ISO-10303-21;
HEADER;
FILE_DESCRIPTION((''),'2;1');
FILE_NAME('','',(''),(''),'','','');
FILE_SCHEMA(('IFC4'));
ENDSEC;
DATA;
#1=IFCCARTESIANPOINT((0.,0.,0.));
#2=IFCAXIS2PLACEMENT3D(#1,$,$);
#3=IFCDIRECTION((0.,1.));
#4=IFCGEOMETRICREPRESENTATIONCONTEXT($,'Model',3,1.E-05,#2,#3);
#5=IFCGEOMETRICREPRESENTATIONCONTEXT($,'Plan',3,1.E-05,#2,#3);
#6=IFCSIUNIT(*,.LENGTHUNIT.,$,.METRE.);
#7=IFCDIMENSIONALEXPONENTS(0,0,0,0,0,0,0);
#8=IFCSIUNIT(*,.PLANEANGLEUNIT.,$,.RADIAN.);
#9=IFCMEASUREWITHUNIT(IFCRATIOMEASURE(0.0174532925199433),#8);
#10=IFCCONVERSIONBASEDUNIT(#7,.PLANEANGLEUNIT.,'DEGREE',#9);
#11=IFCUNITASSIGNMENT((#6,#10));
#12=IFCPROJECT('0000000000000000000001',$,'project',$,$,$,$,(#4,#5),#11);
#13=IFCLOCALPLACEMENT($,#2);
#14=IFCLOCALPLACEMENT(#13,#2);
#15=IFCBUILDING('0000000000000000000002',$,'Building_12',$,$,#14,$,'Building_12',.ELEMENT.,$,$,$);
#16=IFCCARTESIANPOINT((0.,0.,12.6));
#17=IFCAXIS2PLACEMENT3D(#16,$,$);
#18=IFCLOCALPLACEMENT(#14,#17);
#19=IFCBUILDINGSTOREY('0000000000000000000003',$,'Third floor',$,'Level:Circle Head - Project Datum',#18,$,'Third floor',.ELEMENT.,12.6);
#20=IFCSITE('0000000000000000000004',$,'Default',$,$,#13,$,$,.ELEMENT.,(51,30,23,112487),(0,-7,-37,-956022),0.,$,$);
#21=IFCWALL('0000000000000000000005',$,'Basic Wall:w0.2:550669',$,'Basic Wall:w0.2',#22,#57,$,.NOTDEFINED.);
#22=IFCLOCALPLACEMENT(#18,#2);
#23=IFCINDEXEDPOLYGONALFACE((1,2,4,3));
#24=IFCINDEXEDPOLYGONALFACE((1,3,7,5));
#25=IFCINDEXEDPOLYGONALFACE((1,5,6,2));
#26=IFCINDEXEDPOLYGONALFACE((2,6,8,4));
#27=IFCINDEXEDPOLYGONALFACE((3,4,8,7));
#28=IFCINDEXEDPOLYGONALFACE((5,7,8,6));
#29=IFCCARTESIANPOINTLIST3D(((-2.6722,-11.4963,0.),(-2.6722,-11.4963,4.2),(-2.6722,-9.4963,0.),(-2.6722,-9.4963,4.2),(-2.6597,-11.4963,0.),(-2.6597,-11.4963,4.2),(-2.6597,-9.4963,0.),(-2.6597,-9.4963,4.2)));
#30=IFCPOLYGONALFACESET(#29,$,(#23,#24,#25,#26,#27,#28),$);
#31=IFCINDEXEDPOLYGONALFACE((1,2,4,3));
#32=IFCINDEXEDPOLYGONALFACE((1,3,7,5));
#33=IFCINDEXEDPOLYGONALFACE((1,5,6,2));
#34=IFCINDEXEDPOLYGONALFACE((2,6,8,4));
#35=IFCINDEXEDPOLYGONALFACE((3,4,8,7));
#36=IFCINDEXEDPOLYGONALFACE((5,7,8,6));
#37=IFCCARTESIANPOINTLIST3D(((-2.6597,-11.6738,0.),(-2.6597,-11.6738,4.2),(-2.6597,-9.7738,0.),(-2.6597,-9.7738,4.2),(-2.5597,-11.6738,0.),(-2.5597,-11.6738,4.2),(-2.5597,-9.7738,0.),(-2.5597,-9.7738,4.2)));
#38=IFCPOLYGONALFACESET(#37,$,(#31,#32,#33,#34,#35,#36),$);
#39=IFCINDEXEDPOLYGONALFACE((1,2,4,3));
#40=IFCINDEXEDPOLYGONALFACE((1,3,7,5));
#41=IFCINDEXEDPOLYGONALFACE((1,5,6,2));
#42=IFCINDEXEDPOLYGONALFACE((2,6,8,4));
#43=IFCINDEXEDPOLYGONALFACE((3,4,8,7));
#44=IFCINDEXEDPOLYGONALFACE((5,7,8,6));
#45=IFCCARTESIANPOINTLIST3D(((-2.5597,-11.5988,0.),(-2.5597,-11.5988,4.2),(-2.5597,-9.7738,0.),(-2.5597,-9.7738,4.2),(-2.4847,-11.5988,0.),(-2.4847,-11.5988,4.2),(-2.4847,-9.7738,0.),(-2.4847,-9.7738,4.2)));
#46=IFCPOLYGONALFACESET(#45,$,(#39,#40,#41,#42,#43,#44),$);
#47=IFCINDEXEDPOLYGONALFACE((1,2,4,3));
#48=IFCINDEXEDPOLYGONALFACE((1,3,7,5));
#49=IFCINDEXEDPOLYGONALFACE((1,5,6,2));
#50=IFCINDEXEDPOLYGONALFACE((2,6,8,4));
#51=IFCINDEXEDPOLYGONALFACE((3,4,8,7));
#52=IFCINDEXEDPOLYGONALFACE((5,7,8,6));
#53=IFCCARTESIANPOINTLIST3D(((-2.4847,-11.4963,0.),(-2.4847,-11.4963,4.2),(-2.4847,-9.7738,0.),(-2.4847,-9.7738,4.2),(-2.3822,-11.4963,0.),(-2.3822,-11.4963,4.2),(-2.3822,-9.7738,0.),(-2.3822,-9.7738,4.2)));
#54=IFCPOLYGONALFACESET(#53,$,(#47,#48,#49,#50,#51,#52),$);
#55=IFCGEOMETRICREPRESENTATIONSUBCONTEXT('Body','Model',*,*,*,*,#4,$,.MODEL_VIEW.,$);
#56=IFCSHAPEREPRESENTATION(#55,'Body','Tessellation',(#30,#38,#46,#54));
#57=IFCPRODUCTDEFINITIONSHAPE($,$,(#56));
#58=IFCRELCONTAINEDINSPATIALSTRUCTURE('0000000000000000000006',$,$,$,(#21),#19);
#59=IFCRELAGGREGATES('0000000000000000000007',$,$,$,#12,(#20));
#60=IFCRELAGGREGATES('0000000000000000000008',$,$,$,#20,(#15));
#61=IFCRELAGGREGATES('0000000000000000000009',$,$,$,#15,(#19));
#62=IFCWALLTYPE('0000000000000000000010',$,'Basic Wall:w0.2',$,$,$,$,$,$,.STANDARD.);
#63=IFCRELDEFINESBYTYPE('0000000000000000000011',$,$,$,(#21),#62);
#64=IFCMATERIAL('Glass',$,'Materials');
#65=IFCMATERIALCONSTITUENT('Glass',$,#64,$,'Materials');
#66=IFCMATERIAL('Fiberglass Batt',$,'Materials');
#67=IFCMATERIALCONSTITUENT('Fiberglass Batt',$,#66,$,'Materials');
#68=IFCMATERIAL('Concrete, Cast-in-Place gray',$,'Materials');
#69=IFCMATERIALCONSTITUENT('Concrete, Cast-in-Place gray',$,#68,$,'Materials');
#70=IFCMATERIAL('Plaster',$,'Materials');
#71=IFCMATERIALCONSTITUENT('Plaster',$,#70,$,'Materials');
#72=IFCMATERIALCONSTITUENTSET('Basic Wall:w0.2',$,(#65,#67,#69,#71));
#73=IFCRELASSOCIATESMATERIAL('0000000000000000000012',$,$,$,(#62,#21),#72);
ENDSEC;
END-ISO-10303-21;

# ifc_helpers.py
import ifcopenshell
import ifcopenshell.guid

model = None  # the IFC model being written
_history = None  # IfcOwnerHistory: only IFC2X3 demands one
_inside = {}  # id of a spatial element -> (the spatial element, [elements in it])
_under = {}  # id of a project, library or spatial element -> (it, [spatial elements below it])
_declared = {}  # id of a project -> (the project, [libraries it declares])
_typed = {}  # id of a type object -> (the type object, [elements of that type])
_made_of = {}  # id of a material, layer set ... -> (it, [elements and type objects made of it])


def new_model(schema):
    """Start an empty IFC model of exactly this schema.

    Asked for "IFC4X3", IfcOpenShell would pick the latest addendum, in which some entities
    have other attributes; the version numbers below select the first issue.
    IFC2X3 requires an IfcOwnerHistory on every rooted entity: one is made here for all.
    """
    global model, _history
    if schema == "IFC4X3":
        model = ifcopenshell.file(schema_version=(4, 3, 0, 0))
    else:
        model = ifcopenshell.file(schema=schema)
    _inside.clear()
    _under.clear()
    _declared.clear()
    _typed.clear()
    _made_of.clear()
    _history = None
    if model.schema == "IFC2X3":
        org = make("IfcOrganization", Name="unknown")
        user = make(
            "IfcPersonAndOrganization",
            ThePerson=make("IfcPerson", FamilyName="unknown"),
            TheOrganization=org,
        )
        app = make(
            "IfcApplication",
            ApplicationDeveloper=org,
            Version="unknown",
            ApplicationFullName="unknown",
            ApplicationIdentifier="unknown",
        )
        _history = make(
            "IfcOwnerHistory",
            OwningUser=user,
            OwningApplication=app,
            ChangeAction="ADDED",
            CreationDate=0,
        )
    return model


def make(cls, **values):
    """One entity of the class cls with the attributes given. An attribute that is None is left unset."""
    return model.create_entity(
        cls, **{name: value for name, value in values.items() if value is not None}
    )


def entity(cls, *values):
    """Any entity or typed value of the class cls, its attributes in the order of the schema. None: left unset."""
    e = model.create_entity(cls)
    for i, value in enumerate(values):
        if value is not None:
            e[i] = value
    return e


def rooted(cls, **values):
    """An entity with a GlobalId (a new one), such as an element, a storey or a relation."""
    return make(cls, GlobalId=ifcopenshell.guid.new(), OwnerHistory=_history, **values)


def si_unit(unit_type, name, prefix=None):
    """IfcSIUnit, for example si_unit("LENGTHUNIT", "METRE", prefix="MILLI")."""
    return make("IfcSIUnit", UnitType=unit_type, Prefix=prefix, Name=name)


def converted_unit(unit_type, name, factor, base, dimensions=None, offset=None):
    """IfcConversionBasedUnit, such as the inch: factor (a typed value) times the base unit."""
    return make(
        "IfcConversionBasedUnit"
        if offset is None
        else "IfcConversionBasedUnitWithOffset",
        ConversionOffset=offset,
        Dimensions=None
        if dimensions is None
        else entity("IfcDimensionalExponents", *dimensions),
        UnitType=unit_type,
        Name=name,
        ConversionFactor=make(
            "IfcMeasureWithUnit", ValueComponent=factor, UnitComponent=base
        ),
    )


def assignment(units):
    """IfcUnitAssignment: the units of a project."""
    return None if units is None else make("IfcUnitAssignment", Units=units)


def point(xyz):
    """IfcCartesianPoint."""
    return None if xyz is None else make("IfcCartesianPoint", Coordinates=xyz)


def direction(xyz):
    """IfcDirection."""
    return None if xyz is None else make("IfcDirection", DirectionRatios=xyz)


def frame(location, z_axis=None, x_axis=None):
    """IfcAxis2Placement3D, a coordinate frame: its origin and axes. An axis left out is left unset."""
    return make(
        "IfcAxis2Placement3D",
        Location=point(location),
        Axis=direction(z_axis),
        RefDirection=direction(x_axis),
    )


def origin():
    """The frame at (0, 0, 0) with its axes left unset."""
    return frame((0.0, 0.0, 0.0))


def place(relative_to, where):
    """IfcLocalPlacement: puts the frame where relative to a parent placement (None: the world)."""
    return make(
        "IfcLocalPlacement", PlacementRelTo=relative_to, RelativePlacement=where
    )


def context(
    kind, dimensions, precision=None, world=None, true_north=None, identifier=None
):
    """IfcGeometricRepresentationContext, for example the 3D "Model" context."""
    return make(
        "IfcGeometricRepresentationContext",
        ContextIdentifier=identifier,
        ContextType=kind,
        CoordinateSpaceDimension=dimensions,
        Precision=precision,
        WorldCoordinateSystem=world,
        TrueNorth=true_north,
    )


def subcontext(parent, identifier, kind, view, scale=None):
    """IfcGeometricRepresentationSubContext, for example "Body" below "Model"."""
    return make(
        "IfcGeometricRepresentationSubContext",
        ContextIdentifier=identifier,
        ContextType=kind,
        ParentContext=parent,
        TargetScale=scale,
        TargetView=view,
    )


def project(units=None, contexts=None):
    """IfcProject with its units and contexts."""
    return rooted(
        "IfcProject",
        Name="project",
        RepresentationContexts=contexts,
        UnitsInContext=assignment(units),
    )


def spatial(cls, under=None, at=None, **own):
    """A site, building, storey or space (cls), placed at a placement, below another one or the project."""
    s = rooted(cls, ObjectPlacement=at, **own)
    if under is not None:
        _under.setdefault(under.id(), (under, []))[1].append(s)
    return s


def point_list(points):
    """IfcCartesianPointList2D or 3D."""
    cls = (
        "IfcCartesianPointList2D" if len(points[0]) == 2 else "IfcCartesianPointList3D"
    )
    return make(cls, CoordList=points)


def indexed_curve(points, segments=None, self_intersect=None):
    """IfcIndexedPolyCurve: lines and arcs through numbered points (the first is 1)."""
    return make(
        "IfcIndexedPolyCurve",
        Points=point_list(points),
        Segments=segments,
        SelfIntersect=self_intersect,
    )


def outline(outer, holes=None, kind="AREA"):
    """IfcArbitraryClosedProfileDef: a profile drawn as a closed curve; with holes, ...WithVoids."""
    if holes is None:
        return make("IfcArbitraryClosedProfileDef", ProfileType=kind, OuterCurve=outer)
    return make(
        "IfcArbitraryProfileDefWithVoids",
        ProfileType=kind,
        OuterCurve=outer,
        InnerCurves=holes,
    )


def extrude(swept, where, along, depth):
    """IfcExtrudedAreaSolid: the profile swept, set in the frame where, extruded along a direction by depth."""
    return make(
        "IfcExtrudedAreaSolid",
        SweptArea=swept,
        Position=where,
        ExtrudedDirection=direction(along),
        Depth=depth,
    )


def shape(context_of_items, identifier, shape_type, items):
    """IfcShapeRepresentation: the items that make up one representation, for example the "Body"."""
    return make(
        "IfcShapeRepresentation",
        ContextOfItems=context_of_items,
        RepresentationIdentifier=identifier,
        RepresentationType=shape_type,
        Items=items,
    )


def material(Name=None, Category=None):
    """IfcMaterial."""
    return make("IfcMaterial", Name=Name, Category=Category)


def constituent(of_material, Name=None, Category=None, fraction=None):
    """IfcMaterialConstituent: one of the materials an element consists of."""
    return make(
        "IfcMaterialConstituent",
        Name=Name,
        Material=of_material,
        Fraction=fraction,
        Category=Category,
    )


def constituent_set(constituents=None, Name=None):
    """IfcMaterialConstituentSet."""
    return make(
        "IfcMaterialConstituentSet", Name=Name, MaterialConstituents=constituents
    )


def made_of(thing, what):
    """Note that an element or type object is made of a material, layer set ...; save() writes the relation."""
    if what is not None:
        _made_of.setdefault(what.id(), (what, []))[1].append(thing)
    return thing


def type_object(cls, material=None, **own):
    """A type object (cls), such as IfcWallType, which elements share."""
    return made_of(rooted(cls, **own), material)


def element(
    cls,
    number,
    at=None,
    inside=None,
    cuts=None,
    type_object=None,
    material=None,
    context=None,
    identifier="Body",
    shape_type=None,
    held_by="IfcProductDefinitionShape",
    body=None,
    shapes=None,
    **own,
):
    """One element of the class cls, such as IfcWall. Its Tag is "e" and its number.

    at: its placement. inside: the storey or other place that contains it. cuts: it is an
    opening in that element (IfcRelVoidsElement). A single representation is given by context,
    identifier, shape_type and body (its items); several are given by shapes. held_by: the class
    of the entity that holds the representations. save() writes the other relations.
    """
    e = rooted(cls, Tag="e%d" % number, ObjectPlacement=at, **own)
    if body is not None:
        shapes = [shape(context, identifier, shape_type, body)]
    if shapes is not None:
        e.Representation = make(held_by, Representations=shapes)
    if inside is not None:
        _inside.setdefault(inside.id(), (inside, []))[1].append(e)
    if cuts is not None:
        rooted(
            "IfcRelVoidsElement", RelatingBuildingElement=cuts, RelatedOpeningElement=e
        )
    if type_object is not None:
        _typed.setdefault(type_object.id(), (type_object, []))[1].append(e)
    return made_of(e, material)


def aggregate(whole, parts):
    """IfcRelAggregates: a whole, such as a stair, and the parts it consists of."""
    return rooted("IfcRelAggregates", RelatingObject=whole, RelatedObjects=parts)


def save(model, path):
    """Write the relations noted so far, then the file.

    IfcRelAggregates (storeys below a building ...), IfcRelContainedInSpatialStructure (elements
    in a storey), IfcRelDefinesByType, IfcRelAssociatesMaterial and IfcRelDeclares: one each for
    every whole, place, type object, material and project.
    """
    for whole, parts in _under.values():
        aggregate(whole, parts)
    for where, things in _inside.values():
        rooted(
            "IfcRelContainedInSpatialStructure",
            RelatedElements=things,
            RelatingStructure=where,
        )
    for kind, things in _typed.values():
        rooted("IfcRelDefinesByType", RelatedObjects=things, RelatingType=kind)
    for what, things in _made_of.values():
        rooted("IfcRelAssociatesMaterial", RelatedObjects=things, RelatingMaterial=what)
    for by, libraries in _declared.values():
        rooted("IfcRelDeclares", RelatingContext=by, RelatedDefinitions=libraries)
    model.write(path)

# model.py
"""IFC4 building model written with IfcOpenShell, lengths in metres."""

from ifc_helpers import new_model, entity, si_unit, converted_unit, direction, frame, origin, place, context, subcontext, project, spatial, indexed_curve, outline, extrude, material, constituent, constituent_set, type_object, element, save


model = new_model("IFC4")

# Units and contexts
model_context = context("Model", 3, precision=1e-05, world=origin(), true_north=direction((0.0, 1.0)))
plan_context = context("Plan", 3, precision=1e-05, world=origin(), true_north=direction((0.0, 1.0)))
body_context = subcontext(model_context, "Body", "Model", "MODEL_VIEW")
ifc_project = project(units=[si_unit("LENGTHUNIT", "METRE"), converted_unit("PLANEANGLEUNIT", "DEGREE", entity("IfcRatioMeasure", 0.0174532925199433), si_unit("PLANEANGLEUNIT", "RADIAN"), dimensions=[0, 0, 0, 0, 0, 0, 0])], contexts=[model_context, plan_context])

# Site, building, storey
site_placement = place(None, origin())
site = spatial("IfcSite", under=ifc_project, at=site_placement, Name="Default", CompositionType="ELEMENT", RefLatitude=(51, 30, 23, 112487), RefLongitude=(0, -7, -37, -956022), RefElevation=0.0)
building_placement = place(site_placement, origin())
building = spatial("IfcBuilding", under=site, at=building_placement, Name="Building_12", LongName="Building_12", CompositionType="ELEMENT")
storey_placement = place(building_placement, frame((0.0, 0.0, 12.6)))
storey = spatial("IfcBuildingStorey", under=building, at=storey_placement, Name="Third floor", ObjectType="Level:Circle Head - Project Datum", LongName="Third floor", CompositionType="ELEMENT", Elevation=12.6)

# Shared definitions
ifc_material_1 = material(Name="Glass", Category="Materials")
ifc_constituent_1 = constituent(ifc_material_1, Name="Glass", Category="Materials")
ifc_material_2 = material(Name="Fiberglass Batt", Category="Materials")
ifc_constituent_2 = constituent(ifc_material_2, Name="Fiberglass Batt", Category="Materials")
ifc_material_3 = material(Name="Concrete, Cast-in-Place gray", Category="Materials")
ifc_constituent_3 = constituent(ifc_material_3, Name="Concrete, Cast-in-Place gray", Category="Materials")
ifc_material_4 = material(Name="Plaster", Category="Materials")
ifc_constituent_4 = constituent(ifc_material_4, Name="Plaster", Category="Materials")
ifc_constituent_set = constituent_set(constituents=[ifc_constituent_1, ifc_constituent_2, ifc_constituent_3, ifc_constituent_4], Name="Basic Wall:w0.2")
wall_type = type_object("IfcWallType", Name="Basic Wall:w0.2", PredefinedType="STANDARD", material=ifc_constituent_set)

# Wall
wall_1_placement = place(storey_placement, frame((-2.5272, -9.7863, 0.0), z_axis=(0.0, 0.0, 1.0), x_axis=(0.0, -1.0, 0.0)))
element("IfcWall", 1, at=wall_1_placement, inside=storey, type_object=wall_type, material=ifc_constituent_set, Name="Basic Wall:w0.2:550669", ObjectType="Basic Wall:w0.2", PredefinedType="NOTDEFINED", context=body_context, shape_type="SweptSolid", body=[
    extrude(outline(indexed_curve([(-0.0063, -1.0), (0.0062, -1.0), (0.0063, 1.0), (-0.0062, 1.0), (-0.0063, -1.0)], self_intersect=False)), frame((0.71, -0.1388, 0.0), z_axis=(0.0, 0.0, 1.0), x_axis=(0.0, 1.0, 0.0)), (0.0, 0.0, 1.0), 4.2),
    extrude(outline(indexed_curve([(-0.95, -0.05), (0.95, -0.05), (0.95, 0.05), (-0.95, 0.05), (-0.95, -0.05)], self_intersect=False)), frame((0.9375, -0.0825, 0.0)), (0.0, 0.0, 1.0), 4.2),
    extrude(outline(indexed_curve([(-0.9125, -0.0375), (0.9125, -0.0375), (0.9125, 0.0375), (-0.9125, 0.0375), (-0.9125, -0.0375)], self_intersect=False)), frame((0.9, 0.005, 0.0)), (0.0, 0.0, 1.0), 4.2),
    extrude(outline(indexed_curve([(-0.0513, -0.8612), (0.0512, -0.8612), (0.0513, 0.8612), (-0.0512, 0.8612), (-0.0513, -0.8612)], self_intersect=False)), frame((0.8487, 0.0937, 0.0), z_axis=(0.0, 0.0, 1.0), x_axis=(0.0, -1.0, 0.0)), (0.0, 0.0, 1.0), 4.2),
])

save(model, "model.ifc")
